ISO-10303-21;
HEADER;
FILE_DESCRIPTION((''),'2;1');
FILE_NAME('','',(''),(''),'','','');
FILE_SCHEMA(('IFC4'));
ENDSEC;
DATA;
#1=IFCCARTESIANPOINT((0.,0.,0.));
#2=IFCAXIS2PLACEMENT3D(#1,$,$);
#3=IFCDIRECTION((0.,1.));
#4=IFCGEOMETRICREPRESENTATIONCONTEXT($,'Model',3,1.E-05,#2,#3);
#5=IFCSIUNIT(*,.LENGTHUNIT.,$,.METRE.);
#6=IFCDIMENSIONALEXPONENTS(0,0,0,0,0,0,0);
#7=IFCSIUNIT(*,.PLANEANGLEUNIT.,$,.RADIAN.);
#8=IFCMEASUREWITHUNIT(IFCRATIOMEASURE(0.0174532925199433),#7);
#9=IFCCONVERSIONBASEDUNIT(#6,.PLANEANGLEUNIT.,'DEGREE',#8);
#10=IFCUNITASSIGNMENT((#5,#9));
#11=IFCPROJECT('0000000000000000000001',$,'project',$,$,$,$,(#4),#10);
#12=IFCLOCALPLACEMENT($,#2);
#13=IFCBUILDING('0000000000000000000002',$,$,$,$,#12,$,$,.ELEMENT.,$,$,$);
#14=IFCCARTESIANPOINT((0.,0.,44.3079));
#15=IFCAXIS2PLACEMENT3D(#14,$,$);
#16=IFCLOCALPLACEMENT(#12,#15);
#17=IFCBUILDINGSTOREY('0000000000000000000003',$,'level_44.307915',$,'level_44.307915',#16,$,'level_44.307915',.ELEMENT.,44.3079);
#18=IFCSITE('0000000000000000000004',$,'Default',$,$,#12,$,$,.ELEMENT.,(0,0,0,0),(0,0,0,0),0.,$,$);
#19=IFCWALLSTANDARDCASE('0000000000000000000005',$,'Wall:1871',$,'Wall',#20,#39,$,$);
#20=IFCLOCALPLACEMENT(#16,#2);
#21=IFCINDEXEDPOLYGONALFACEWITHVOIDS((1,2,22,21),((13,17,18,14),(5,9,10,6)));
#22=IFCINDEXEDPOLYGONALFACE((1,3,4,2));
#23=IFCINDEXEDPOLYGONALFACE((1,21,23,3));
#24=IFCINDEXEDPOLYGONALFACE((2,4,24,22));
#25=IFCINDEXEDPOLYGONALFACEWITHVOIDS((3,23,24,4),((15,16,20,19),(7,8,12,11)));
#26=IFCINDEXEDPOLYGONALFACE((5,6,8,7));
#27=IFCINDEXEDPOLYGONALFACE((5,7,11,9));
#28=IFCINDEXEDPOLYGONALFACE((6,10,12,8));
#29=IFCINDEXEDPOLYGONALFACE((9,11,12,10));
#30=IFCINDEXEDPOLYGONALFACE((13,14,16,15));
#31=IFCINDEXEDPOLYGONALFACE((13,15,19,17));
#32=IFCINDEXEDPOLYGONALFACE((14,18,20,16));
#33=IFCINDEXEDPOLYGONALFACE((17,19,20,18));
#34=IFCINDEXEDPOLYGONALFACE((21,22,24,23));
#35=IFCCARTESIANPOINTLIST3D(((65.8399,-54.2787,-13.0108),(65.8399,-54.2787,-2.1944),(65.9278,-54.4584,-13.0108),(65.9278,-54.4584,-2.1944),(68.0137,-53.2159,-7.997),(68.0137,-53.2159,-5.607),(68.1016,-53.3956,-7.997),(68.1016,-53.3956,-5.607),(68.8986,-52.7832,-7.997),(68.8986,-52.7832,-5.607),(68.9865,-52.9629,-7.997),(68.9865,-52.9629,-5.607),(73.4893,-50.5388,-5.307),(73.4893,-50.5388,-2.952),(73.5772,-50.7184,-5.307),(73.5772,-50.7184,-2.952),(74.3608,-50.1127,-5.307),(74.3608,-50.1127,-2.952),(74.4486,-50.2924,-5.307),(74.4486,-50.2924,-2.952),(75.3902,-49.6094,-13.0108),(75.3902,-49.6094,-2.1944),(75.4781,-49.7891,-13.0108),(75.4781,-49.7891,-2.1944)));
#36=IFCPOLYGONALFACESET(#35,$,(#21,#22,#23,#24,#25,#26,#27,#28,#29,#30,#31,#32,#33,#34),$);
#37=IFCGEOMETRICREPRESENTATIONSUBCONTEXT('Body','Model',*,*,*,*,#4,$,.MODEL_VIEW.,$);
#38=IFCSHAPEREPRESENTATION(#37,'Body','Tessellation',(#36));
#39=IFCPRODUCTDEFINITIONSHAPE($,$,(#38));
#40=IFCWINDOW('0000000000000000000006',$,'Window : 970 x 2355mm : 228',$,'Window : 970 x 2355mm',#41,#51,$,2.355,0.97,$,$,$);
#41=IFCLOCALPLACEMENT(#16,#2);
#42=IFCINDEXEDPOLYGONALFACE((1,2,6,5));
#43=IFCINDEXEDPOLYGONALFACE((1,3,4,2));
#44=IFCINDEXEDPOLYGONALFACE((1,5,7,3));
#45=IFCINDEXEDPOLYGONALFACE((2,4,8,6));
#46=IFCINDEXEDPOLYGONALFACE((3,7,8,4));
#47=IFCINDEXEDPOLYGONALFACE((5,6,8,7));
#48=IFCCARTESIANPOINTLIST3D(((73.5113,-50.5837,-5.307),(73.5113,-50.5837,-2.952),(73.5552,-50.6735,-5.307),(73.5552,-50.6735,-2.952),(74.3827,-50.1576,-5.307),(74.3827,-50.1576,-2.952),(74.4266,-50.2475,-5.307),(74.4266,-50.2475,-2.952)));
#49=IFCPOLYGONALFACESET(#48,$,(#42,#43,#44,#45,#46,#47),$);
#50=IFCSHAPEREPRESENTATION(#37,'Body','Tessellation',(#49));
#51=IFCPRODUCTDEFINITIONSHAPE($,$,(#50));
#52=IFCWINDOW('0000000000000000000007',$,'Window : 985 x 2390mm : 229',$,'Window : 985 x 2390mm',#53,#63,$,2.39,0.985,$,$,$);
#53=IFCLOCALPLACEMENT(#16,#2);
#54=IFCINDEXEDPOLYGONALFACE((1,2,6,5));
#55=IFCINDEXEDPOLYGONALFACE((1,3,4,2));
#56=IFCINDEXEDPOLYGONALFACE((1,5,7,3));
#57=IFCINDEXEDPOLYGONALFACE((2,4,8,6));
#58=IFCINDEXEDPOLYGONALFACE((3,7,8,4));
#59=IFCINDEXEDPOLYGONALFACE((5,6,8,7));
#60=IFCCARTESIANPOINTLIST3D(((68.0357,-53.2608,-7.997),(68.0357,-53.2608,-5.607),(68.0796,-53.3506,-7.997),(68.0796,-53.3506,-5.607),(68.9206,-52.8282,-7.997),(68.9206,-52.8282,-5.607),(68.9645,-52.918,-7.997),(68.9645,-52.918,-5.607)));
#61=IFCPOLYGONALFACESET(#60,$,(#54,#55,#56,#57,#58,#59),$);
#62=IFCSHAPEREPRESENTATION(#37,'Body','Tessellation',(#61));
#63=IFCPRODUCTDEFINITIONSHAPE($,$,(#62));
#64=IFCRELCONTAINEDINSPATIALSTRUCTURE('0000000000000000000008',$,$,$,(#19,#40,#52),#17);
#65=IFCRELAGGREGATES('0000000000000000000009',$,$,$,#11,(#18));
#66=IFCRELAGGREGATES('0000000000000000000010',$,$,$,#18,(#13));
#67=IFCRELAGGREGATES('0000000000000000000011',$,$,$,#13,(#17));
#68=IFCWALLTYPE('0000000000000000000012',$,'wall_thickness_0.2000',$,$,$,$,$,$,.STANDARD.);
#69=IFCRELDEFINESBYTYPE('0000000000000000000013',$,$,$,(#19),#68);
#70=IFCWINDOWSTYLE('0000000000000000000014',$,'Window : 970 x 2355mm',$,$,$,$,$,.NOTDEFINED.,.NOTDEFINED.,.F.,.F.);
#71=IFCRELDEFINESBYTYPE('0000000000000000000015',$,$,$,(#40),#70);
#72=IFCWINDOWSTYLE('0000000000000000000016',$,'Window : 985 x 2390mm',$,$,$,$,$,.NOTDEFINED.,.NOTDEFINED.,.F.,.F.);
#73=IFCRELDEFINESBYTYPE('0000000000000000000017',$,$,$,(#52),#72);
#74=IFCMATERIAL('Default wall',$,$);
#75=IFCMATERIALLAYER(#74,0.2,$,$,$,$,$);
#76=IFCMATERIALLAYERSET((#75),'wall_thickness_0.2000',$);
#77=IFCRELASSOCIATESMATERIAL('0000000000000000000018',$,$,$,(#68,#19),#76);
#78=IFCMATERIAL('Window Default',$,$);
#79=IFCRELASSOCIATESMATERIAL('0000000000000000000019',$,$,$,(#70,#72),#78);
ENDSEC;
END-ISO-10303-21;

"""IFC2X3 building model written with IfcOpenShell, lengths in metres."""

from ifc_helpers import new_model, entity, si_unit, converted_unit, direction, frame, frame_2d, origin, origin_2d_with_axis, place, context, subcontext, project, spatial, polyline, rectangle, outline, extrude, source, transform, mapped, material, layer, layer_set, layer_usage, type_object, type_shapes, element, fill, save


model = new_model("IFC2X3")

# Units and contexts
model_context = context("Model", 3, precision=1e-05, world=origin(), true_north=direction((0.0, 1.0)))
body_context = subcontext(model_context, "Body", "Model", "MODEL_VIEW")
ifc_project = project(units=[si_unit("LENGTHUNIT", "METRE"), converted_unit("PLANEANGLEUNIT", "DEGREE", entity("IfcRatioMeasure", 0.0174532925199433), si_unit("PLANEANGLEUNIT", "RADIAN"), dimensions=[0, 0, 0, 0, 0, 0, 0])], contexts=[model_context])

# Site, building, storey
placement_1 = place(None, origin())
site = spatial("IfcSite", under=ifc_project, at=placement_1, Name="Default", CompositionType="ELEMENT", RefLatitude=(0, 0, 0, 0), RefLongitude=(0, 0, 0, 0), RefElevation=0.0)
building = spatial("IfcBuilding", under=site, at=placement_1, CompositionType="ELEMENT")
storey_placement = place(placement_1, frame((0.0, 0.0, 44.3079)))
storey = spatial("IfcBuildingStorey", under=building, at=storey_placement, Name="level_44.307915", ObjectType="level_44.307915", LongName="level_44.307915", CompositionType="ELEMENT", Elevation=44.3079)

# Shared definitions
ifc_material_1 = material(Name="Default wall")
ifc_layer = layer(ifc_material_1, 0.2)
ifc_layer_set = layer_set([ifc_layer], Name="wall_thickness_0.2000")
ifc_layer_usage = layer_usage(ifc_layer_set, "AXIS2", "POSITIVE", -0.1)
wall_type = type_object("IfcWallType", Name="wall_thickness_0.2000", PredefinedType="STANDARD", material=ifc_layer_set)

# Wall, openings, windows
placement_2 = place(placement_1, frame((0.0, 0.0, 31.2971)))
wall_1_placement = place(placement_2, frame((65.8838, -54.3685, 0.0), z_axis=(0.0, 0.0, 1.0), x_axis=(0.898374, 0.439231, 0.0)))
wall_1 = element("IfcWallStandardCase", 1, at=wall_1_placement, inside=storey, type_object=wall_type, material=ifc_layer_usage, Name="Wall:1871", ObjectType="Wall", context=body_context, shape_type="SweptSolid", body=[
    extrude(outline(polyline([(10.6307, -0.1), (10.6307, 0.1), (0.0, 0.1), (0.0, -0.1), (10.6307, -0.1)])), origin(), (0.0, 0.0, 1.0), 10.8165),
])
opening_1_placement = place(wall_1_placement, frame((8.5147, -0.1, 7.7038)))
opening_1 = element("IfcOpeningElement", 2, at=opening_1_placement, cuts=wall_1, ObjectType="Opening", context=body_context, shape_type="SweptSolid", body=[
    extrude(rectangle(XDim=0.97, YDim=2.355, at=frame_2d((1.1775, 0.485), x_axis=(0.0, 1.0))), frame((0.0, 0.0, 0.0), z_axis=(0.0, 1.0, 0.0), x_axis=(0.0, 0.0, 1.0)), (0.0, 0.0, 1.0), 0.2),
])
opening_2_placement = place(wall_1_placement, frame((2.4197, -0.1, 5.0138)))
opening_2 = element("IfcOpeningElement", 3, at=opening_2_placement, cuts=wall_1, ObjectType="Opening", context=body_context, shape_type="SweptSolid", body=[
    extrude(rectangle(XDim=0.985, YDim=2.39, at=frame_2d((1.195, 0.4925), x_axis=(0.0, 1.0))), frame((0.0, 0.0, 0.0), z_axis=(0.0, 1.0, 0.0), x_axis=(0.0, 0.0, 1.0)), (0.0, 0.0, 1.0), 0.2),
])
ifc_material_2 = material(Name="Window Default")
window_style_1 = type_object("IfcWindowStyle", Name="Window : 970 x 2355mm", ConstructionType="NOTDEFINED", OperationType="NOTDEFINED", ParameterTakesPrecedence=False, Sizeable=False, material=ifc_material_2)
shared_shape_1 = source(origin(), body_context, "Body", "SweptSolid", [
    extrude(rectangle(XDim=0.1, YDim=0.97, at=origin_2d_with_axis()), frame((0.485, 0.1, 0.0), z_axis=(0.0, 0.0, 1.0), x_axis=(0.0, 1.0, 0.0)), (0.0, 0.0, 1.0), 2.355),
])
type_shapes(window_style_1, [shared_shape_1])
window_1_placement = place(opening_1_placement, origin())
window_1 = element("IfcWindow", 4, at=window_1_placement, inside=storey, type_object=window_style_1, Name="Window : 970 x 2355mm : 228", ObjectType="Window : 970 x 2355mm", OverallHeight=2.355, OverallWidth=0.97, context=body_context, shape_type="MappedRepresentation", body=[
    mapped(shared_shape_1, transform((0.0, 0.0, 0.0), scale=1.0)),
])
fill(opening_1, window_1)
window_style_2 = type_object("IfcWindowStyle", Name="Window : 985 x 2390mm", ConstructionType="NOTDEFINED", OperationType="NOTDEFINED", ParameterTakesPrecedence=False, Sizeable=False, material=ifc_material_2)
shared_shape_2 = source(origin(), body_context, "Body", "SweptSolid", [
    extrude(rectangle(XDim=0.1, YDim=0.985, at=origin_2d_with_axis()), frame((0.4925, 0.1, 0.0), z_axis=(0.0, 0.0, 1.0), x_axis=(0.0, 1.0, 0.0)), (0.0, 0.0, 1.0), 2.39),
])
type_shapes(window_style_2, [shared_shape_2])
window_2_placement = place(opening_2_placement, origin())
window_2 = element("IfcWindow", 5, at=window_2_placement, inside=storey, type_object=window_style_2, Name="Window : 985 x 2390mm : 229", ObjectType="Window : 985 x 2390mm", OverallHeight=2.39, OverallWidth=0.985, context=body_context, shape_type="MappedRepresentation", body=[
    mapped(shared_shape_2, transform((0.0, 0.0, 0.0), scale=1.0)),
])
fill(opening_2, window_2)

save(model, "model.ifc")
